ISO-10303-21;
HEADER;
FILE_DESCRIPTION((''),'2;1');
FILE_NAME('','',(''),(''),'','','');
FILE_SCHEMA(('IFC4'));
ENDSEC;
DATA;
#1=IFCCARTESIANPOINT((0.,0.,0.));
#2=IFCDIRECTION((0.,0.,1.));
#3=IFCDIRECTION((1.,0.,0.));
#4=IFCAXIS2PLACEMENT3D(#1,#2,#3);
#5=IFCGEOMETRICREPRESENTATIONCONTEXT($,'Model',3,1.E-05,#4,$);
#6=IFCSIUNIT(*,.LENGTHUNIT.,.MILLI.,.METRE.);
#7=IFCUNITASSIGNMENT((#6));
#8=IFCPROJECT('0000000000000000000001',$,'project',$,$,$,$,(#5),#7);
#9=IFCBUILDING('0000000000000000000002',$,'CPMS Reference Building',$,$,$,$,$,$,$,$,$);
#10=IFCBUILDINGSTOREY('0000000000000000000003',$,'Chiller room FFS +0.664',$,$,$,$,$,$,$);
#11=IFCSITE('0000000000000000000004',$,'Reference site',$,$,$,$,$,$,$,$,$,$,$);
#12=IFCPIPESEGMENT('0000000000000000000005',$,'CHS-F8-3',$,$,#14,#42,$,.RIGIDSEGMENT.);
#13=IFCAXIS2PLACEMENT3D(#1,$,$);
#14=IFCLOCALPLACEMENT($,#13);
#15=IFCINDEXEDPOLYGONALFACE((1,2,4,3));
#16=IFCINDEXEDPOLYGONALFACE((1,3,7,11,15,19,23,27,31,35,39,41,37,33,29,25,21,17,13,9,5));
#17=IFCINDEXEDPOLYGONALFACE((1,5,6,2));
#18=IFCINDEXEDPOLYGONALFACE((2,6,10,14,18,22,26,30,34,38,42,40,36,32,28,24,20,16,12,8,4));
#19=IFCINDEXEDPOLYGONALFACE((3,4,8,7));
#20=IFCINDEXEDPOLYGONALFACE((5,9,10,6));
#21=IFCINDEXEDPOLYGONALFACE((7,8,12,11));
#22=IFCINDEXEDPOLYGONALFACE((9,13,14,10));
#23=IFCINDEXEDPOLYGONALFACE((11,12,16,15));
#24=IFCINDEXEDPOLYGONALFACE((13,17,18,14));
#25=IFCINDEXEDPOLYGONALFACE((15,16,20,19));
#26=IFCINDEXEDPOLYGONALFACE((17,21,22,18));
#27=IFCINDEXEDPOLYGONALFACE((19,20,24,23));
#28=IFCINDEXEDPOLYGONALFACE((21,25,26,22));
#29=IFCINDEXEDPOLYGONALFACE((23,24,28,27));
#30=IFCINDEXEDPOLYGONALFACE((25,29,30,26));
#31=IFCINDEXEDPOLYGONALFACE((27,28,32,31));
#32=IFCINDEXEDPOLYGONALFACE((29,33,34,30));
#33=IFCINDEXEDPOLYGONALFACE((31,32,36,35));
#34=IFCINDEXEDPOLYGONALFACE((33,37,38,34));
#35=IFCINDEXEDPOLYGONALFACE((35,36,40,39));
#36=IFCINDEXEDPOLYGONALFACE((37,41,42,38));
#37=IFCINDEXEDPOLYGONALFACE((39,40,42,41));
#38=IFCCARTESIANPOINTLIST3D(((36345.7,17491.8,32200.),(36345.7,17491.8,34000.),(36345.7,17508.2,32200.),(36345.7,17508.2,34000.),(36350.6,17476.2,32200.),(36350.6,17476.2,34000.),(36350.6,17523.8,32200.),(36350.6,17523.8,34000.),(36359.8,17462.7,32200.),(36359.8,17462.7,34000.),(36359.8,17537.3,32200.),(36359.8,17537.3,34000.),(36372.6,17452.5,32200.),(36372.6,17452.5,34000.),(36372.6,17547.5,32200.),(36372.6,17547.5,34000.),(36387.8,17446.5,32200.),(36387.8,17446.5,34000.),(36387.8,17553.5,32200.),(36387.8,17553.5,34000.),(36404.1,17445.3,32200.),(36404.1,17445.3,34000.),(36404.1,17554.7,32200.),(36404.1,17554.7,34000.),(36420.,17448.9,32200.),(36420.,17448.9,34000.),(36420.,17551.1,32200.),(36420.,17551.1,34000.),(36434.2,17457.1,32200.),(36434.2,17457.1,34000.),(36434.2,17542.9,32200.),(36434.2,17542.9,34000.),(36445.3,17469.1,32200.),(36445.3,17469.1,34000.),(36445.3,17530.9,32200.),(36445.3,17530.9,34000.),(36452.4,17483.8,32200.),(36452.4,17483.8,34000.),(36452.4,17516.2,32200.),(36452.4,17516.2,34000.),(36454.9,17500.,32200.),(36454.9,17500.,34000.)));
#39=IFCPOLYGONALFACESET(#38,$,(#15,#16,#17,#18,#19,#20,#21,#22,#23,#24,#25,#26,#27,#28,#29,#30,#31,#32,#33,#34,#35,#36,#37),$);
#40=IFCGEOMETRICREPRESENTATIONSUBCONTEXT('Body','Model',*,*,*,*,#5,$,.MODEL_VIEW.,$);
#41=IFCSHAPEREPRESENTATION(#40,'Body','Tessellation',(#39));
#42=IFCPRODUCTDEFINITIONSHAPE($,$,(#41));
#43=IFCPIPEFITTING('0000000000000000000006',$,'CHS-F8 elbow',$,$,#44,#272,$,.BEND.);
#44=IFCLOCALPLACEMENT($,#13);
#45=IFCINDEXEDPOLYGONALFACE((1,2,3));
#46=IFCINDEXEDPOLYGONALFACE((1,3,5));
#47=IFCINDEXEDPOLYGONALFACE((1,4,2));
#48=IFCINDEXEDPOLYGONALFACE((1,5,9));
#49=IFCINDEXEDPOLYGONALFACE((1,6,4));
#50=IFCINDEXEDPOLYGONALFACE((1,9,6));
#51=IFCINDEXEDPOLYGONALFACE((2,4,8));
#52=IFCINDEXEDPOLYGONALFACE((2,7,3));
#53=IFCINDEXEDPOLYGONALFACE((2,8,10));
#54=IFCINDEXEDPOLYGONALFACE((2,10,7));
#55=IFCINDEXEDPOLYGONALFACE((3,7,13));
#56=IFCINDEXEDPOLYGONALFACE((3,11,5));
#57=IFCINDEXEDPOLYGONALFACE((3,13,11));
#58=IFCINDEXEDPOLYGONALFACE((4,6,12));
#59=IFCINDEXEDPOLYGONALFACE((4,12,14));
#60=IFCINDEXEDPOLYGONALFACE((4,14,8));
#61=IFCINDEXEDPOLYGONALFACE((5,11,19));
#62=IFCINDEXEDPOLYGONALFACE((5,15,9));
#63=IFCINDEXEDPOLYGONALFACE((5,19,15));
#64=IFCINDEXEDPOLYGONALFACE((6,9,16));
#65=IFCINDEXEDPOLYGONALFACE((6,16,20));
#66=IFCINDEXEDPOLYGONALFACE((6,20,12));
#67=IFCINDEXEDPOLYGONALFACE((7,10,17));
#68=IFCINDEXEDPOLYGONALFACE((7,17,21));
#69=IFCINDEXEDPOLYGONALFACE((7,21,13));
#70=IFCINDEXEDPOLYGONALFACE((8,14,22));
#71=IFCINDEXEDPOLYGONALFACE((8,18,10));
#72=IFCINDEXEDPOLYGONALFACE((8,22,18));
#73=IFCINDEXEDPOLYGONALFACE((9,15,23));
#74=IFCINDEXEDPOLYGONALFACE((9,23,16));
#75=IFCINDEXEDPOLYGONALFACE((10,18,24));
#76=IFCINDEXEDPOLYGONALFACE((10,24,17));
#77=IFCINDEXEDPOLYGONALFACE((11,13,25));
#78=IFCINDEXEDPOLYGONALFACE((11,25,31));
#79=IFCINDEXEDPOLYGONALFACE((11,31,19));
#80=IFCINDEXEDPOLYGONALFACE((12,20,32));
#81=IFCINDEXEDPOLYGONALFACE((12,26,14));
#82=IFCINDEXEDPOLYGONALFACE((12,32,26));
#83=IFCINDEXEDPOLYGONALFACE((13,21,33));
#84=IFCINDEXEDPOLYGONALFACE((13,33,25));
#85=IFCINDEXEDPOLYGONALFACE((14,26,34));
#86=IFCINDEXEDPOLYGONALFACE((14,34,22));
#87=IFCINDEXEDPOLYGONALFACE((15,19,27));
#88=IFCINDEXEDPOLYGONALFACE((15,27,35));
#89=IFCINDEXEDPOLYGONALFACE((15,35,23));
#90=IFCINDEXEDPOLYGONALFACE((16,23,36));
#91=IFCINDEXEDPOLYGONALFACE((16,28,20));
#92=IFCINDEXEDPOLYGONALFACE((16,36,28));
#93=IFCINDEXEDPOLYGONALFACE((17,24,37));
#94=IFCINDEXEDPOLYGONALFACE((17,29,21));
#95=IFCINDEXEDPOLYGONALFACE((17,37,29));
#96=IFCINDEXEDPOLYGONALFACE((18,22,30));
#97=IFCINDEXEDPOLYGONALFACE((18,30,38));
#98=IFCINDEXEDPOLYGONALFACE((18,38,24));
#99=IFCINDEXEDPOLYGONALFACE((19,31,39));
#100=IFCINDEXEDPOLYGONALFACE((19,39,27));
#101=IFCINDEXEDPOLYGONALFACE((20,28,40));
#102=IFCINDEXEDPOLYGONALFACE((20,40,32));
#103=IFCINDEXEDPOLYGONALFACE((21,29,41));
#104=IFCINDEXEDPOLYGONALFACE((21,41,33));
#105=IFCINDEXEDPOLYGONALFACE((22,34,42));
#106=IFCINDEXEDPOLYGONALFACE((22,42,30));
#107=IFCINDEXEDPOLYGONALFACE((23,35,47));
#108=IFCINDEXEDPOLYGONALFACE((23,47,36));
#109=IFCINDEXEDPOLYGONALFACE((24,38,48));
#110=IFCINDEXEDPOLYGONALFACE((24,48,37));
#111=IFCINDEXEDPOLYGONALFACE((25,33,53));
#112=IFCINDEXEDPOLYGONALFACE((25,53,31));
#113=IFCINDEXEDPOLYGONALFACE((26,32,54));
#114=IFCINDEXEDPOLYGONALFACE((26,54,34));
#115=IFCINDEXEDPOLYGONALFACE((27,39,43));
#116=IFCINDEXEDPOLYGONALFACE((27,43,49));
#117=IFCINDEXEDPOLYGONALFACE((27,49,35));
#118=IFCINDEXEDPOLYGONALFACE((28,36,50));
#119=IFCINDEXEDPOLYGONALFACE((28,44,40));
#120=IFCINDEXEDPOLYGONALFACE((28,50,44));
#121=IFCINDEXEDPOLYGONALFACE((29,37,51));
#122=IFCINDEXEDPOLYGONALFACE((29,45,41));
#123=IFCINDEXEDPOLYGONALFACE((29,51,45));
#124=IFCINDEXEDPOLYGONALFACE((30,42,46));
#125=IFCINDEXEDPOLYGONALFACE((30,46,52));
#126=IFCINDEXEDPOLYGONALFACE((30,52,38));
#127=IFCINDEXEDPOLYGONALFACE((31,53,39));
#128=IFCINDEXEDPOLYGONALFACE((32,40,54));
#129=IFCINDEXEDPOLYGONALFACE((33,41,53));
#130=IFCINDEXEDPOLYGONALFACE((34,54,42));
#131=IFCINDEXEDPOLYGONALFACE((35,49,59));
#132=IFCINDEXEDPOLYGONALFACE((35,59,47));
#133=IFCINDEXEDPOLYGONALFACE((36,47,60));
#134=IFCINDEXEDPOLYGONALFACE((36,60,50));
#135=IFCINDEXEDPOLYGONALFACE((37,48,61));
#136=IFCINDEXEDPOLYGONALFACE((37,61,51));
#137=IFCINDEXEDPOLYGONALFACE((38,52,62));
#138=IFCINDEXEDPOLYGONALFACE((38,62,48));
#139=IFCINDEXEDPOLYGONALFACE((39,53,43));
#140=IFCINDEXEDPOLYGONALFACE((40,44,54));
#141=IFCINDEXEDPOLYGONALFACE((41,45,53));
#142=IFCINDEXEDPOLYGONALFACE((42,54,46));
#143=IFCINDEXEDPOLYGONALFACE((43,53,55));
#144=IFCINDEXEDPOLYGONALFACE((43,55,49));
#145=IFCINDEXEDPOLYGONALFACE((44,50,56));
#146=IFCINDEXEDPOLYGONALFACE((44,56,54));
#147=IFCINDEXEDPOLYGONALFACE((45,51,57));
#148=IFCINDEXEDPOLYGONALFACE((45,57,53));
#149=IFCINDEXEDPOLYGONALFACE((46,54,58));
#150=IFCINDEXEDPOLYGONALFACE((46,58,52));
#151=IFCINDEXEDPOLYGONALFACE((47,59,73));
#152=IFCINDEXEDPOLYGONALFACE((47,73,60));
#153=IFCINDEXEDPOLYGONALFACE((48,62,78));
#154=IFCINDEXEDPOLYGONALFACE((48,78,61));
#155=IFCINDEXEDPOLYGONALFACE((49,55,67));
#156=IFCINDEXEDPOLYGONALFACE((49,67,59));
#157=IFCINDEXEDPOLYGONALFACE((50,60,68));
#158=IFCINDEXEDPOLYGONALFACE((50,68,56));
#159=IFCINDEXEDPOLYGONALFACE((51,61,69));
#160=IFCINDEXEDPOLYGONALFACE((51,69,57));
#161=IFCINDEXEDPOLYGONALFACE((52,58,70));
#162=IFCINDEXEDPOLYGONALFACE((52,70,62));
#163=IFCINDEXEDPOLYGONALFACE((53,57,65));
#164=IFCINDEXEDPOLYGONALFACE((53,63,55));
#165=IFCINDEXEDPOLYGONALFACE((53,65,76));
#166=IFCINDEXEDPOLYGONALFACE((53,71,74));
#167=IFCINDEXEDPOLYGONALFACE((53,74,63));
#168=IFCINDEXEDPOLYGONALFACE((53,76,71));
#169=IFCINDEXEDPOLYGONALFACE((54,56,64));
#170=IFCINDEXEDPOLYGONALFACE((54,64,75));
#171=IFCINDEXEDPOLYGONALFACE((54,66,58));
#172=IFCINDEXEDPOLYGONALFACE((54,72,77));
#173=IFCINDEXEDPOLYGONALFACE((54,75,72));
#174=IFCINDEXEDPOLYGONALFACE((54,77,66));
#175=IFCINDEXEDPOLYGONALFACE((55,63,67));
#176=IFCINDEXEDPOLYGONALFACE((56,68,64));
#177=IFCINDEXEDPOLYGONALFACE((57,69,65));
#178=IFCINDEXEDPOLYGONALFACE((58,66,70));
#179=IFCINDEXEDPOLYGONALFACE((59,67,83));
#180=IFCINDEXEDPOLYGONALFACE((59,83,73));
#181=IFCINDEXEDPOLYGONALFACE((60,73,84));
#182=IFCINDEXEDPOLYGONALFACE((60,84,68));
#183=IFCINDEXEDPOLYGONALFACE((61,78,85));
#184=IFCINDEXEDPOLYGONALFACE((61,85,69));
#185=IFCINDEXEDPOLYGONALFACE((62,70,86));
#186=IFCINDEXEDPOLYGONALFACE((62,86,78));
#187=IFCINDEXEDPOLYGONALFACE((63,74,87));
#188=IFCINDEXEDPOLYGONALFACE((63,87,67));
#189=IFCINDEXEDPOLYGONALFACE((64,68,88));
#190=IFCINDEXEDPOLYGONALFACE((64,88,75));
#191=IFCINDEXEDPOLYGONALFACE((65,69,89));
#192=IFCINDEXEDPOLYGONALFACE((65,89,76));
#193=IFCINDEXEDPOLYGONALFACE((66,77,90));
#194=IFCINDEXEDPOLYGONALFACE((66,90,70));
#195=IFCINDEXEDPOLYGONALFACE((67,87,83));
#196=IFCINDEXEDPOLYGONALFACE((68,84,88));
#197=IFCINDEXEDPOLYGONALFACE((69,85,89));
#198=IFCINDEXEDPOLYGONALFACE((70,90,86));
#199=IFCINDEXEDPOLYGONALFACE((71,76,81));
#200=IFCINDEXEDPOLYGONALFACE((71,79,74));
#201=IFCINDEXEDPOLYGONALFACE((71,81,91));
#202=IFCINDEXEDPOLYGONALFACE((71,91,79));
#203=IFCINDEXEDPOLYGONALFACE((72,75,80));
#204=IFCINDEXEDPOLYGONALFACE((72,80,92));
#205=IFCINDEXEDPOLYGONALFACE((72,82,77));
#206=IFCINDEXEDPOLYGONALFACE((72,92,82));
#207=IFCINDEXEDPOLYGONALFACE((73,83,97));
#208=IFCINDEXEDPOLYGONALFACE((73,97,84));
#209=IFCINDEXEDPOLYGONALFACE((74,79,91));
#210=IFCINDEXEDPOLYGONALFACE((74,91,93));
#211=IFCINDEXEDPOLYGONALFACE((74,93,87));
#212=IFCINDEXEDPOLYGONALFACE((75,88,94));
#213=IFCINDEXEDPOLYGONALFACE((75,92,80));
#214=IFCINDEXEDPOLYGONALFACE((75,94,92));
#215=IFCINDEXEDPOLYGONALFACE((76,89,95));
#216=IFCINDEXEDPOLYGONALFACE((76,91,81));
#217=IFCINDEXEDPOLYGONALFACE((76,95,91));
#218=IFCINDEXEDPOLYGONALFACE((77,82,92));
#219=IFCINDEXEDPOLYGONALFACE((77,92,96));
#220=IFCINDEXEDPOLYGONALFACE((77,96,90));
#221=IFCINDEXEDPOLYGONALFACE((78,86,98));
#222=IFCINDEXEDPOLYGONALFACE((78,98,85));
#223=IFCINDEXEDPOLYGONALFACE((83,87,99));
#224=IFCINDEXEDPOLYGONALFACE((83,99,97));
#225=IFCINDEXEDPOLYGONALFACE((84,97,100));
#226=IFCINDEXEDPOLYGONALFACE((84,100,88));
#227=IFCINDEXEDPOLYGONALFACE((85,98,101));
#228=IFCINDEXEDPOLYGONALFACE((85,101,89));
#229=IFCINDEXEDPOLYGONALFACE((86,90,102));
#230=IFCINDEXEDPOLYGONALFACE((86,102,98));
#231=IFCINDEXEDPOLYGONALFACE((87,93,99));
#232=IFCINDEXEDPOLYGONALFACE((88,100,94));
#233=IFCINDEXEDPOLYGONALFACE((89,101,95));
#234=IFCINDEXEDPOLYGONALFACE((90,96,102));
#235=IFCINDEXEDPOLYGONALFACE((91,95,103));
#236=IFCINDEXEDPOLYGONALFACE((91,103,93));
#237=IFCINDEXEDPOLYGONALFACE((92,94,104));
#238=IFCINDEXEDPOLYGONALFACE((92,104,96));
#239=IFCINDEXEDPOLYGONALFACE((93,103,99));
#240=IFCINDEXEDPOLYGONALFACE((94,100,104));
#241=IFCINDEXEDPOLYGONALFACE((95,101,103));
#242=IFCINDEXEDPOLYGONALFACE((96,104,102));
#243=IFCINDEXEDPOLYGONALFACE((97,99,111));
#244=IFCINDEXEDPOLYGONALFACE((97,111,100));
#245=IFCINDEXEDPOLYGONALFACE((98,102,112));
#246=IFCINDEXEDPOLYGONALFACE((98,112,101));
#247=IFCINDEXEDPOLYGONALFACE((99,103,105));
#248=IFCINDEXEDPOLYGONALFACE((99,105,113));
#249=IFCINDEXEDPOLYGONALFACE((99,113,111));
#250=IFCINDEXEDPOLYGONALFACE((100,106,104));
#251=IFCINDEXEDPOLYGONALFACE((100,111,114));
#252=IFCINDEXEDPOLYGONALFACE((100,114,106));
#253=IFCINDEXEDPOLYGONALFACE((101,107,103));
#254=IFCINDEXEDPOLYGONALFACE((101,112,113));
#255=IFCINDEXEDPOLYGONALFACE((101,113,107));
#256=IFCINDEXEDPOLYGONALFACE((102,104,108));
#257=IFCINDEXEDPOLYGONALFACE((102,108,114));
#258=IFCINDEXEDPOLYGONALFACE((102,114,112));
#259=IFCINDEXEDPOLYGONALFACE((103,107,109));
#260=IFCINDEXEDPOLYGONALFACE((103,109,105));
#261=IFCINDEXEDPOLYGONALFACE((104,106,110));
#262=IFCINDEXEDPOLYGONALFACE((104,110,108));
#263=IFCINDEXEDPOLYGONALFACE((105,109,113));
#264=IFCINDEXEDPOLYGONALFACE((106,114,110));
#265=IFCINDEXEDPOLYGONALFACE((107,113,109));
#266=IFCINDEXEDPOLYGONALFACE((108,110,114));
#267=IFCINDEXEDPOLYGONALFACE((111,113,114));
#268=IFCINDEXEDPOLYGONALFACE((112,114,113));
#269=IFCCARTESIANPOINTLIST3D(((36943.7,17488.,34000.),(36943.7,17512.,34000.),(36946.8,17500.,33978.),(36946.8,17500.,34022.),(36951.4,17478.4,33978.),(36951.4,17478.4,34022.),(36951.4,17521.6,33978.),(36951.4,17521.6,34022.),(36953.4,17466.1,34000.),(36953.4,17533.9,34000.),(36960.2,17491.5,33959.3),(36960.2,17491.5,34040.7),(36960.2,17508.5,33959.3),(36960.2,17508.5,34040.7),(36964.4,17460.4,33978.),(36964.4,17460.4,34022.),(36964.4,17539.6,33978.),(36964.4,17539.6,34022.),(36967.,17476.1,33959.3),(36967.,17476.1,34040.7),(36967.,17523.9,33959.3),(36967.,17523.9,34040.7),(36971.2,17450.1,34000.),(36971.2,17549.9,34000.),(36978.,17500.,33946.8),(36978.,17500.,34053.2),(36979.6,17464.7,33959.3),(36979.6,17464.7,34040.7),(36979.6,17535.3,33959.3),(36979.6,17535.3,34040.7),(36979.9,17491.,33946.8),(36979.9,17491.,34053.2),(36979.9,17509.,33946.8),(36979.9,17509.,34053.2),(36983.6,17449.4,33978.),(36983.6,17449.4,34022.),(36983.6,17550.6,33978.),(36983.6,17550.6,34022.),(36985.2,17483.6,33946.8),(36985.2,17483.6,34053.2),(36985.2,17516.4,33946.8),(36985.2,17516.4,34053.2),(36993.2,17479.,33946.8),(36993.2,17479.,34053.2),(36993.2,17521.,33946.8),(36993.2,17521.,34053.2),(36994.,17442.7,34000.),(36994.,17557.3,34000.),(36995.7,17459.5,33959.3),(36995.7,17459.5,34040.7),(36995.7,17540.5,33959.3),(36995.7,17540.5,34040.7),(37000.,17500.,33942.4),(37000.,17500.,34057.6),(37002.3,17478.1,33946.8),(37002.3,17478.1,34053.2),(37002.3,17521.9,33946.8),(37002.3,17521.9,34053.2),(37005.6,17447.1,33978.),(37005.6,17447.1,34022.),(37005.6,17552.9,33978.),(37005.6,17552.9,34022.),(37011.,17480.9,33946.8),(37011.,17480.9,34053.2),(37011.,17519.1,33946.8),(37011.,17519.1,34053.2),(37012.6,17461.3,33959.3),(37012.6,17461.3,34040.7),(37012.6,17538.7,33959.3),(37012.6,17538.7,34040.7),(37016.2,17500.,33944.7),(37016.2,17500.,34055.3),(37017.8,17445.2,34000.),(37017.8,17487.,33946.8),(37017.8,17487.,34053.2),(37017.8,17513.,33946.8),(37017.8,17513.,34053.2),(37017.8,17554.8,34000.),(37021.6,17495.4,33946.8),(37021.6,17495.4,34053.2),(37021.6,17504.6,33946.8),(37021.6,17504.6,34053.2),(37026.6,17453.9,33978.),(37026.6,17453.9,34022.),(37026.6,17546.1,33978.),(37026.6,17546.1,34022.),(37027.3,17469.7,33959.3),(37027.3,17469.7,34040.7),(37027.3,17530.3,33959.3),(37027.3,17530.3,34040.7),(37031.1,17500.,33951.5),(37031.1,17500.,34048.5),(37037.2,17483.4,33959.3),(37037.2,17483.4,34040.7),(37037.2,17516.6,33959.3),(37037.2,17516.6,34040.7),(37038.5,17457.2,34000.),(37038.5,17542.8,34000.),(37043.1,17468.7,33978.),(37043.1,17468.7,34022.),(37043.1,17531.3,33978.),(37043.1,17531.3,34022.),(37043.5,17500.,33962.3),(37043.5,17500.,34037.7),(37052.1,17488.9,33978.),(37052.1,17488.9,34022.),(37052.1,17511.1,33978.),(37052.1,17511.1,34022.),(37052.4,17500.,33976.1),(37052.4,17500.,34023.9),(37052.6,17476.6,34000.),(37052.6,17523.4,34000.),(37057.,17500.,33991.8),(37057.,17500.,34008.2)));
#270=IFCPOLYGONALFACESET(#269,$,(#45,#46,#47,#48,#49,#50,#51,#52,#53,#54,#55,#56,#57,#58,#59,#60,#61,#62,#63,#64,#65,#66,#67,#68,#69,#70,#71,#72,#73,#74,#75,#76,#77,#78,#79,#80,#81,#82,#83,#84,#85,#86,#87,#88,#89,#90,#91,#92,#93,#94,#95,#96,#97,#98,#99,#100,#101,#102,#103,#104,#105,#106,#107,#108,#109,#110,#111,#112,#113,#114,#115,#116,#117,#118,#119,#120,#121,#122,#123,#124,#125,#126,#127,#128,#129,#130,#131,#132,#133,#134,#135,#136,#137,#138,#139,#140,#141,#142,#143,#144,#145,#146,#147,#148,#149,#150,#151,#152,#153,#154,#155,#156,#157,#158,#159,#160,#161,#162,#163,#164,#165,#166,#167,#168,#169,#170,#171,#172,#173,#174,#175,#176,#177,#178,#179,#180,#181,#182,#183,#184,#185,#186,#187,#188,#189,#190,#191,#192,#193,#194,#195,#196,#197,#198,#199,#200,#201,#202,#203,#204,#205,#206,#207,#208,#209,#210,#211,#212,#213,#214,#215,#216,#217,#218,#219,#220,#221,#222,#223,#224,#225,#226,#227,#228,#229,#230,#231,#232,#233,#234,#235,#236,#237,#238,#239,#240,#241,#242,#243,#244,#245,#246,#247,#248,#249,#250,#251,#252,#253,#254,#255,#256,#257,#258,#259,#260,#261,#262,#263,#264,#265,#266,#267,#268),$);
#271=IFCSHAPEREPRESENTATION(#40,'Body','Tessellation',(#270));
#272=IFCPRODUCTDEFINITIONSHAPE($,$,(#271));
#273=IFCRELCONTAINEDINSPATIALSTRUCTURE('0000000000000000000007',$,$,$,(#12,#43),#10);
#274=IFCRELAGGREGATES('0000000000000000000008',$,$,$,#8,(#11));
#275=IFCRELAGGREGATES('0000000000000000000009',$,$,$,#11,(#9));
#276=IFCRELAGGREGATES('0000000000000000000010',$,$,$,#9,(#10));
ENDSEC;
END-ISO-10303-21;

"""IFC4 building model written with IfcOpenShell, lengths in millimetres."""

from ifc_helpers import new_model, entity, si_unit, frame, origin_with_axes, origin_2d, place, context, subcontext, project, spatial, circle_curve, outline, extrude, element, save


model = new_model("IFC4")

# Units and contexts
model_context = context("Model", 3, precision=1e-05, world=origin_with_axes())
body_context = subcontext(model_context, "Body", "Model", "MODEL_VIEW")
ifc_project = project(units=[si_unit("LENGTHUNIT", "METRE", prefix="MILLI")], contexts=[model_context])

# Site, building, storey
site = spatial("IfcSite", under=ifc_project, Name="Reference site")
building = spatial("IfcBuilding", under=site, Name="CPMS Reference Building")
storey = spatial("IfcBuildingStorey", under=building, Name="Chiller room FFS +0.664")

# Pipe segment
pipe_segment_1_placement = place(None, origin_with_axes())
element("IfcPipeSegment", 1, at=pipe_segment_1_placement, inside=storey, Name="CHS-F8-3", PredefinedType="RIGIDSEGMENT", context=body_context, shape_type="SweptSolid", body=[
    extrude(outline(circle_curve(origin_2d(), 54.9)), frame((36400.0, 17500.0, 34000.0), z_axis=(0.0, 0.0, -1.0), x_axis=(1.0, 0.0, 0.0)), (0.0, 0.0, 1.0), 1800.0),
])

# Pipe fitting
pipe_fitting_1_placement = place(None, origin_with_axes())
element("IfcPipeFitting", 2, at=pipe_fitting_1_placement, inside=storey, Name="CHS-F8 elbow", PredefinedType="BEND", context=body_context, shape_type="CSG", body=[
    entity("IfcSphere", entity("IfcAxis2Placement3D", entity("IfcCartesianPoint", [37000.0, 17500.0, 34000.0]), entity("IfcDirection", [0.0, 0.0, 1.0]), entity("IfcDirection", [1.0, 0.0, 0.0])), 57.6),
])

save(model, "model.ifc")
